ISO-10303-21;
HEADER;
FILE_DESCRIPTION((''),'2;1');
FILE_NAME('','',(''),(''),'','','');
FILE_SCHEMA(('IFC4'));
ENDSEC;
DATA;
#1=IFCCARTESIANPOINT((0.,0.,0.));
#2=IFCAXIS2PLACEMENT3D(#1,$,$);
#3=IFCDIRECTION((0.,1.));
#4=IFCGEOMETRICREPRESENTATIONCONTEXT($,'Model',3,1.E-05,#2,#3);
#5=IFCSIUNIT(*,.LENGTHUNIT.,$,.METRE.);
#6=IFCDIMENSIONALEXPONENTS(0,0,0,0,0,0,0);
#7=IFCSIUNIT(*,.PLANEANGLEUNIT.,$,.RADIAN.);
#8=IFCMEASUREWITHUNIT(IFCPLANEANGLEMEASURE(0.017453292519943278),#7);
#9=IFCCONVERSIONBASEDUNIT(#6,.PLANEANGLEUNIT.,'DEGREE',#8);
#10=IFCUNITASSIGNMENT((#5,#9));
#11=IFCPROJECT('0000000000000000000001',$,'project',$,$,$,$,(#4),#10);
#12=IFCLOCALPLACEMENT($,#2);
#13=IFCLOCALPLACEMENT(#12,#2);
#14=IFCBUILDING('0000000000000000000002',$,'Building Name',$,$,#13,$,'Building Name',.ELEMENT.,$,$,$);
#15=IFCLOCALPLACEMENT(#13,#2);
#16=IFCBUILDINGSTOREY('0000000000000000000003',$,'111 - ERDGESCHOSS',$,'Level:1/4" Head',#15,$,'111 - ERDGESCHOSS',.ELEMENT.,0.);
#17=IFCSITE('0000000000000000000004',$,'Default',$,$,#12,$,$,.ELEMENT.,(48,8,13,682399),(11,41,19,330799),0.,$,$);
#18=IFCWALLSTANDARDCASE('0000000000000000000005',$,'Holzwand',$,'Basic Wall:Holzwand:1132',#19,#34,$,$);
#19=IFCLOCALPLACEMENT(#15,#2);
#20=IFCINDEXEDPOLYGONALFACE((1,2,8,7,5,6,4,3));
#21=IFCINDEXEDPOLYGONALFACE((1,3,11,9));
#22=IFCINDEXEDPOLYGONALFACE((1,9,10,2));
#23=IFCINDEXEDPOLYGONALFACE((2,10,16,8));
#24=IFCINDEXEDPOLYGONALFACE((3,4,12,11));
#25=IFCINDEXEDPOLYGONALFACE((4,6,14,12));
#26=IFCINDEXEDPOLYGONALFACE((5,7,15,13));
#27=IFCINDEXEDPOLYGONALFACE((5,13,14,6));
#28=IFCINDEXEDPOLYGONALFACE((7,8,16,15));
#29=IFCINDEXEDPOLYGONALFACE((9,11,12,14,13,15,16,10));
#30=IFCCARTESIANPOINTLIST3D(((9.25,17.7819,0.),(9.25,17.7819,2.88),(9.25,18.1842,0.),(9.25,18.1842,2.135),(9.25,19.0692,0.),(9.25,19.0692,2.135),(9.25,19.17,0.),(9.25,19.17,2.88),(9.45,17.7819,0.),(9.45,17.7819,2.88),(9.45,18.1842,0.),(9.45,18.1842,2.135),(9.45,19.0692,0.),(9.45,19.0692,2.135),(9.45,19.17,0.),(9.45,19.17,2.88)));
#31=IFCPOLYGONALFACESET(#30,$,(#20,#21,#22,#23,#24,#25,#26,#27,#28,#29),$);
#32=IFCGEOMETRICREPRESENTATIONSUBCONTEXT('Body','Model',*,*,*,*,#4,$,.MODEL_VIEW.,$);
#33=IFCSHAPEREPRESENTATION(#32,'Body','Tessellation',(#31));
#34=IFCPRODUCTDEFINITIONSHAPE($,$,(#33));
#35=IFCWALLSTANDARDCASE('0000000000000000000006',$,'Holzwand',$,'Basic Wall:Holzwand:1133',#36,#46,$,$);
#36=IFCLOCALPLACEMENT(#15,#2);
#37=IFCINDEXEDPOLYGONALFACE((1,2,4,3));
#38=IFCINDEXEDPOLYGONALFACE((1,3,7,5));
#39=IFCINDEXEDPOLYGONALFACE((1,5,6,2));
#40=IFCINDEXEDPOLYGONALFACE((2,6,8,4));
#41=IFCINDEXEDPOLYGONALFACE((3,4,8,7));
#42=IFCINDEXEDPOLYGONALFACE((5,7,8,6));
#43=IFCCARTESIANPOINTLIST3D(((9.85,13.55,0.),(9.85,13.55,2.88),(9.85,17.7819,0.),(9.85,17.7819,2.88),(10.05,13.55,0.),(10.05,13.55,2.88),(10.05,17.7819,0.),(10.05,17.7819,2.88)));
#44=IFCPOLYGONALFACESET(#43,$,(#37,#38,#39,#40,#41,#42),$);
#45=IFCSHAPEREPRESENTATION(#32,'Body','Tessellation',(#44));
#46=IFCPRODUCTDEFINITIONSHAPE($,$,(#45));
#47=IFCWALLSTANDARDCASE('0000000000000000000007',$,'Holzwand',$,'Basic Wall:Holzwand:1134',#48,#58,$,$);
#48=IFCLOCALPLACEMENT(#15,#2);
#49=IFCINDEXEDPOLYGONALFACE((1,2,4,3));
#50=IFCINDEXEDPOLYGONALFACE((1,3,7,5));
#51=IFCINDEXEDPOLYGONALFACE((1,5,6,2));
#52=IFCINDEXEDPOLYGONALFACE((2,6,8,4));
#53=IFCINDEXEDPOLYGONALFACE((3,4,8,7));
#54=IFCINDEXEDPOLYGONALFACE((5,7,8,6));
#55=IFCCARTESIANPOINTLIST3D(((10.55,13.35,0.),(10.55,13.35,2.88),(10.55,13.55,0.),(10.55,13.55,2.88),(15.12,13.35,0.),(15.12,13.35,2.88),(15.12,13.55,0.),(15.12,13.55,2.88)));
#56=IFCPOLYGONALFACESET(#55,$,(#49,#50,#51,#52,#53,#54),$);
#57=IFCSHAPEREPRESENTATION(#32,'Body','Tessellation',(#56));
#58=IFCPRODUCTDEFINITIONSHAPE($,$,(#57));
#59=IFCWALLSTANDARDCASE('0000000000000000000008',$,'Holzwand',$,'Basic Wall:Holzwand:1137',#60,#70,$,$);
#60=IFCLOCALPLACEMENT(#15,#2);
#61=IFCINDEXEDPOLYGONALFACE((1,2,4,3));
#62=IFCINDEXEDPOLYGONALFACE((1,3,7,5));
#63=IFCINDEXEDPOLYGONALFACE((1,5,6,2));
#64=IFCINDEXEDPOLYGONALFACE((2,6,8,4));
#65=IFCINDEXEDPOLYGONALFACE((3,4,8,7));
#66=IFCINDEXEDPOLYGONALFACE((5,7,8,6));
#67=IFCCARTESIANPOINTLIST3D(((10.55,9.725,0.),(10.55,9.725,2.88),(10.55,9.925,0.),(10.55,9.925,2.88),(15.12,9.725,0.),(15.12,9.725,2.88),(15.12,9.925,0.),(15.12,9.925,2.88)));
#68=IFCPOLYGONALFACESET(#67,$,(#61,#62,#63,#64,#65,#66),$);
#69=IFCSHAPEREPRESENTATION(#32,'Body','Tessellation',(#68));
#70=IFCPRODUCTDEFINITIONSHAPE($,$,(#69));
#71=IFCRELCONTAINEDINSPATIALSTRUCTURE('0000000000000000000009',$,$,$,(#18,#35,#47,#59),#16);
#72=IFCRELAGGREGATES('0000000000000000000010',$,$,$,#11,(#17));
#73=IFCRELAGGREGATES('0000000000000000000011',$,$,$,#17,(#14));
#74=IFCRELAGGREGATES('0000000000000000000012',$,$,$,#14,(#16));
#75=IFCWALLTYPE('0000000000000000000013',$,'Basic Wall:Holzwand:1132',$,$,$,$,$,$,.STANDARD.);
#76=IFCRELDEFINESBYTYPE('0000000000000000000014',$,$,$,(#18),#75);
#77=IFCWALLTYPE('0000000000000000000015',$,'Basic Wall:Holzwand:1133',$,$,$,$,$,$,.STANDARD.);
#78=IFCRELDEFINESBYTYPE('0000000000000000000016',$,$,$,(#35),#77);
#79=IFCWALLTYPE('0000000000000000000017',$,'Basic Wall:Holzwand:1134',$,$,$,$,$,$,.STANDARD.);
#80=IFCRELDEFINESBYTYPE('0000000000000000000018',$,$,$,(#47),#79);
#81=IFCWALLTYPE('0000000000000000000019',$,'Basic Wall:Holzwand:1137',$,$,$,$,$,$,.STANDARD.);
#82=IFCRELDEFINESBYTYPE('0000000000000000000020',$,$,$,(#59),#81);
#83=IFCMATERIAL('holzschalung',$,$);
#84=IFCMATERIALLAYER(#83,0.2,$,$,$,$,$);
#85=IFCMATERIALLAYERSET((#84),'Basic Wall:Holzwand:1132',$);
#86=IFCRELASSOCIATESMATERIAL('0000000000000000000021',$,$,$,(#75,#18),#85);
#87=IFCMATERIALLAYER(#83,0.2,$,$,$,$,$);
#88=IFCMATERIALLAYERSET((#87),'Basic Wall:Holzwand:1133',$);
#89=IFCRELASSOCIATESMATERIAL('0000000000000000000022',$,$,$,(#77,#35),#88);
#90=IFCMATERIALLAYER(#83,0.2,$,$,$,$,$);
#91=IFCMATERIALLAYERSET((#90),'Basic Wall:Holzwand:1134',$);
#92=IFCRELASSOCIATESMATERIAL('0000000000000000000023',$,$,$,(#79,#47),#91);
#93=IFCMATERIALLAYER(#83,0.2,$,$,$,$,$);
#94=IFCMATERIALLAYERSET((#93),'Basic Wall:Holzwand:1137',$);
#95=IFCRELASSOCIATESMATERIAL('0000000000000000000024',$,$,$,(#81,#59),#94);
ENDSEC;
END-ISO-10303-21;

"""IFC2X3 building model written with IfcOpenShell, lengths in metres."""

from ifc_helpers import new_model, entity, si_unit, converted_unit, direction, frame, frame_2d, origin, place, context, subcontext, project, spatial, rectangle, extrude, material, layer, layer_set, layer_usage, type_object, element, save


model = new_model("IFC2X3")

# Units and contexts
model_context = context("Model", 3, precision=1e-05, world=origin(), true_north=direction((0.0, 1.0)))
body_context = subcontext(model_context, "Body", "Model", "MODEL_VIEW")
ifc_project = project(units=[si_unit("LENGTHUNIT", "METRE"), converted_unit("PLANEANGLEUNIT", "DEGREE", entity("IfcPlaneAngleMeasure", 0.017453292519943278), si_unit("PLANEANGLEUNIT", "RADIAN"), dimensions=[0, 0, 0, 0, 0, 0, 0])], contexts=[model_context])

# Site, building, storey
site_placement = place(None, origin())
site = spatial("IfcSite", under=ifc_project, at=site_placement, Name="Default", CompositionType="ELEMENT", RefLatitude=(48, 8, 13, 682399), RefLongitude=(11, 41, 19, 330799), RefElevation=0.0)
building_placement = place(site_placement, origin())
building = spatial("IfcBuilding", under=site, at=building_placement, Name="Building Name", LongName="Building Name", CompositionType="ELEMENT")
storey_placement = place(building_placement, origin())
storey = spatial("IfcBuildingStorey", under=building, at=storey_placement, Name="111 - ERDGESCHOSS", ObjectType="Level:1/4\" Head", LongName="111 - ERDGESCHOSS", CompositionType="ELEMENT", Elevation=0.0)

# Shared definitions
ifc_material = material(Name="holzschalung")

# Wall, opening
ifc_layer_1 = layer(ifc_material, 0.2)
ifc_layer_set_1 = layer_set([ifc_layer_1], Name="Basic Wall:Holzwand:1132")
ifc_layer_usage_1 = layer_usage(ifc_layer_set_1, "AXIS2", "NEGATIVE", 0.1)
wall_type_1 = type_object("IfcWallType", Name="Basic Wall:Holzwand:1132", PredefinedType="STANDARD", material=ifc_layer_set_1)
wall_1_placement = place(storey_placement, frame((9.35, 17.7819, 0.0), z_axis=(0.0, 0.0, 1.0), x_axis=(0.0, 1.0, 0.0)))
wall_1 = element("IfcWallStandardCase", 1, at=wall_1_placement, inside=storey, type_object=wall_type_1, material=ifc_layer_usage_1, Name="Holzwand", ObjectType="Basic Wall:Holzwand:1132", context=body_context, shape_type="SweptSolid", body=[
    extrude(rectangle(XDim=1.3881, YDim=0.2, at=frame_2d((0.6941, 0.0), x_axis=(-1.0, 0.0))), origin(), (0.0, 0.0, 1.0), 2.88),
])
opening_1_placement = place(wall_1_placement, frame((-17.7819, 9.35, 0.0), z_axis=(0.0, 0.0, 1.0), x_axis=(0.0, -1.0, 0.0)))
element("IfcOpeningElement", 2, at=opening_1_placement, cuts=wall_1, ObjectType="Opening", context=body_context, shape_type="SweptSolid", body=[
    extrude(rectangle(XDim=2.135, YDim=0.885, at=frame_2d((0.0, 0.0), x_axis=(1.0, 0.0))), frame((9.452, 18.6267, 1.0675), z_axis=(-1.0, 0.0, 0.0), x_axis=(0.0, 0.0, 1.0)), (0.0, 0.0, 1.0), 0.204),
])

# Walls
ifc_layer_2 = layer(ifc_material, 0.2)
ifc_layer_set_2 = layer_set([ifc_layer_2], Name="Basic Wall:Holzwand:1133")
ifc_layer_usage_2 = layer_usage(ifc_layer_set_2, "AXIS2", "NEGATIVE", 0.1)
wall_type_2 = type_object("IfcWallType", Name="Basic Wall:Holzwand:1133", PredefinedType="STANDARD", material=ifc_layer_set_2)
wall_2_placement = place(storey_placement, frame((9.95, 13.55, 0.0), z_axis=(0.0, 0.0, 1.0), x_axis=(0.0, 1.0, 0.0)))
element("IfcWallStandardCase", 3, at=wall_2_placement, inside=storey, type_object=wall_type_2, material=ifc_layer_usage_2, Name="Holzwand", ObjectType="Basic Wall:Holzwand:1133", context=body_context, shape_type="SweptSolid", body=[
    extrude(rectangle(XDim=4.2319, YDim=0.2, at=frame_2d((2.1159, 0.0), x_axis=(-1.0, 0.0))), origin(), (0.0, 0.0, 1.0), 2.88),
])
ifc_layer_3 = layer(ifc_material, 0.2)
ifc_layer_set_3 = layer_set([ifc_layer_3], Name="Basic Wall:Holzwand:1134")
ifc_layer_usage_3 = layer_usage(ifc_layer_set_3, "AXIS2", "NEGATIVE", 0.1)
wall_type_3 = type_object("IfcWallType", Name="Basic Wall:Holzwand:1134", PredefinedType="STANDARD", material=ifc_layer_set_3)
wall_3_placement = place(storey_placement, frame((10.55, 13.45, 0.0)))
element("IfcWallStandardCase", 4, at=wall_3_placement, inside=storey, type_object=wall_type_3, material=ifc_layer_usage_3, Name="Holzwand", ObjectType="Basic Wall:Holzwand:1134", context=body_context, shape_type="SweptSolid", body=[
    extrude(rectangle(XDim=4.57, YDim=0.2, at=frame_2d((2.285, 0.0), x_axis=(-1.0, 0.0))), origin(), (0.0, 0.0, 1.0), 2.88),
])
ifc_layer_4 = layer(ifc_material, 0.2)
ifc_layer_set_4 = layer_set([ifc_layer_4], Name="Basic Wall:Holzwand:1137")
ifc_layer_usage_4 = layer_usage(ifc_layer_set_4, "AXIS2", "NEGATIVE", 0.1)
wall_type_4 = type_object("IfcWallType", Name="Basic Wall:Holzwand:1137", PredefinedType="STANDARD", material=ifc_layer_set_4)
wall_4_placement = place(storey_placement, frame((15.12, 9.825, 0.0), z_axis=(0.0, 0.0, 1.0), x_axis=(-1.0, 0.0, 0.0)))
element("IfcWallStandardCase", 5, at=wall_4_placement, inside=storey, type_object=wall_type_4, material=ifc_layer_usage_4, Name="Holzwand", ObjectType="Basic Wall:Holzwand:1137", context=body_context, shape_type="SweptSolid", body=[
    extrude(rectangle(XDim=4.57, YDim=0.2, at=frame_2d((2.285, 0.0), x_axis=(-1.0, 0.0))), origin(), (0.0, 0.0, 1.0), 2.88),
])

save(model, "model.ifc")
